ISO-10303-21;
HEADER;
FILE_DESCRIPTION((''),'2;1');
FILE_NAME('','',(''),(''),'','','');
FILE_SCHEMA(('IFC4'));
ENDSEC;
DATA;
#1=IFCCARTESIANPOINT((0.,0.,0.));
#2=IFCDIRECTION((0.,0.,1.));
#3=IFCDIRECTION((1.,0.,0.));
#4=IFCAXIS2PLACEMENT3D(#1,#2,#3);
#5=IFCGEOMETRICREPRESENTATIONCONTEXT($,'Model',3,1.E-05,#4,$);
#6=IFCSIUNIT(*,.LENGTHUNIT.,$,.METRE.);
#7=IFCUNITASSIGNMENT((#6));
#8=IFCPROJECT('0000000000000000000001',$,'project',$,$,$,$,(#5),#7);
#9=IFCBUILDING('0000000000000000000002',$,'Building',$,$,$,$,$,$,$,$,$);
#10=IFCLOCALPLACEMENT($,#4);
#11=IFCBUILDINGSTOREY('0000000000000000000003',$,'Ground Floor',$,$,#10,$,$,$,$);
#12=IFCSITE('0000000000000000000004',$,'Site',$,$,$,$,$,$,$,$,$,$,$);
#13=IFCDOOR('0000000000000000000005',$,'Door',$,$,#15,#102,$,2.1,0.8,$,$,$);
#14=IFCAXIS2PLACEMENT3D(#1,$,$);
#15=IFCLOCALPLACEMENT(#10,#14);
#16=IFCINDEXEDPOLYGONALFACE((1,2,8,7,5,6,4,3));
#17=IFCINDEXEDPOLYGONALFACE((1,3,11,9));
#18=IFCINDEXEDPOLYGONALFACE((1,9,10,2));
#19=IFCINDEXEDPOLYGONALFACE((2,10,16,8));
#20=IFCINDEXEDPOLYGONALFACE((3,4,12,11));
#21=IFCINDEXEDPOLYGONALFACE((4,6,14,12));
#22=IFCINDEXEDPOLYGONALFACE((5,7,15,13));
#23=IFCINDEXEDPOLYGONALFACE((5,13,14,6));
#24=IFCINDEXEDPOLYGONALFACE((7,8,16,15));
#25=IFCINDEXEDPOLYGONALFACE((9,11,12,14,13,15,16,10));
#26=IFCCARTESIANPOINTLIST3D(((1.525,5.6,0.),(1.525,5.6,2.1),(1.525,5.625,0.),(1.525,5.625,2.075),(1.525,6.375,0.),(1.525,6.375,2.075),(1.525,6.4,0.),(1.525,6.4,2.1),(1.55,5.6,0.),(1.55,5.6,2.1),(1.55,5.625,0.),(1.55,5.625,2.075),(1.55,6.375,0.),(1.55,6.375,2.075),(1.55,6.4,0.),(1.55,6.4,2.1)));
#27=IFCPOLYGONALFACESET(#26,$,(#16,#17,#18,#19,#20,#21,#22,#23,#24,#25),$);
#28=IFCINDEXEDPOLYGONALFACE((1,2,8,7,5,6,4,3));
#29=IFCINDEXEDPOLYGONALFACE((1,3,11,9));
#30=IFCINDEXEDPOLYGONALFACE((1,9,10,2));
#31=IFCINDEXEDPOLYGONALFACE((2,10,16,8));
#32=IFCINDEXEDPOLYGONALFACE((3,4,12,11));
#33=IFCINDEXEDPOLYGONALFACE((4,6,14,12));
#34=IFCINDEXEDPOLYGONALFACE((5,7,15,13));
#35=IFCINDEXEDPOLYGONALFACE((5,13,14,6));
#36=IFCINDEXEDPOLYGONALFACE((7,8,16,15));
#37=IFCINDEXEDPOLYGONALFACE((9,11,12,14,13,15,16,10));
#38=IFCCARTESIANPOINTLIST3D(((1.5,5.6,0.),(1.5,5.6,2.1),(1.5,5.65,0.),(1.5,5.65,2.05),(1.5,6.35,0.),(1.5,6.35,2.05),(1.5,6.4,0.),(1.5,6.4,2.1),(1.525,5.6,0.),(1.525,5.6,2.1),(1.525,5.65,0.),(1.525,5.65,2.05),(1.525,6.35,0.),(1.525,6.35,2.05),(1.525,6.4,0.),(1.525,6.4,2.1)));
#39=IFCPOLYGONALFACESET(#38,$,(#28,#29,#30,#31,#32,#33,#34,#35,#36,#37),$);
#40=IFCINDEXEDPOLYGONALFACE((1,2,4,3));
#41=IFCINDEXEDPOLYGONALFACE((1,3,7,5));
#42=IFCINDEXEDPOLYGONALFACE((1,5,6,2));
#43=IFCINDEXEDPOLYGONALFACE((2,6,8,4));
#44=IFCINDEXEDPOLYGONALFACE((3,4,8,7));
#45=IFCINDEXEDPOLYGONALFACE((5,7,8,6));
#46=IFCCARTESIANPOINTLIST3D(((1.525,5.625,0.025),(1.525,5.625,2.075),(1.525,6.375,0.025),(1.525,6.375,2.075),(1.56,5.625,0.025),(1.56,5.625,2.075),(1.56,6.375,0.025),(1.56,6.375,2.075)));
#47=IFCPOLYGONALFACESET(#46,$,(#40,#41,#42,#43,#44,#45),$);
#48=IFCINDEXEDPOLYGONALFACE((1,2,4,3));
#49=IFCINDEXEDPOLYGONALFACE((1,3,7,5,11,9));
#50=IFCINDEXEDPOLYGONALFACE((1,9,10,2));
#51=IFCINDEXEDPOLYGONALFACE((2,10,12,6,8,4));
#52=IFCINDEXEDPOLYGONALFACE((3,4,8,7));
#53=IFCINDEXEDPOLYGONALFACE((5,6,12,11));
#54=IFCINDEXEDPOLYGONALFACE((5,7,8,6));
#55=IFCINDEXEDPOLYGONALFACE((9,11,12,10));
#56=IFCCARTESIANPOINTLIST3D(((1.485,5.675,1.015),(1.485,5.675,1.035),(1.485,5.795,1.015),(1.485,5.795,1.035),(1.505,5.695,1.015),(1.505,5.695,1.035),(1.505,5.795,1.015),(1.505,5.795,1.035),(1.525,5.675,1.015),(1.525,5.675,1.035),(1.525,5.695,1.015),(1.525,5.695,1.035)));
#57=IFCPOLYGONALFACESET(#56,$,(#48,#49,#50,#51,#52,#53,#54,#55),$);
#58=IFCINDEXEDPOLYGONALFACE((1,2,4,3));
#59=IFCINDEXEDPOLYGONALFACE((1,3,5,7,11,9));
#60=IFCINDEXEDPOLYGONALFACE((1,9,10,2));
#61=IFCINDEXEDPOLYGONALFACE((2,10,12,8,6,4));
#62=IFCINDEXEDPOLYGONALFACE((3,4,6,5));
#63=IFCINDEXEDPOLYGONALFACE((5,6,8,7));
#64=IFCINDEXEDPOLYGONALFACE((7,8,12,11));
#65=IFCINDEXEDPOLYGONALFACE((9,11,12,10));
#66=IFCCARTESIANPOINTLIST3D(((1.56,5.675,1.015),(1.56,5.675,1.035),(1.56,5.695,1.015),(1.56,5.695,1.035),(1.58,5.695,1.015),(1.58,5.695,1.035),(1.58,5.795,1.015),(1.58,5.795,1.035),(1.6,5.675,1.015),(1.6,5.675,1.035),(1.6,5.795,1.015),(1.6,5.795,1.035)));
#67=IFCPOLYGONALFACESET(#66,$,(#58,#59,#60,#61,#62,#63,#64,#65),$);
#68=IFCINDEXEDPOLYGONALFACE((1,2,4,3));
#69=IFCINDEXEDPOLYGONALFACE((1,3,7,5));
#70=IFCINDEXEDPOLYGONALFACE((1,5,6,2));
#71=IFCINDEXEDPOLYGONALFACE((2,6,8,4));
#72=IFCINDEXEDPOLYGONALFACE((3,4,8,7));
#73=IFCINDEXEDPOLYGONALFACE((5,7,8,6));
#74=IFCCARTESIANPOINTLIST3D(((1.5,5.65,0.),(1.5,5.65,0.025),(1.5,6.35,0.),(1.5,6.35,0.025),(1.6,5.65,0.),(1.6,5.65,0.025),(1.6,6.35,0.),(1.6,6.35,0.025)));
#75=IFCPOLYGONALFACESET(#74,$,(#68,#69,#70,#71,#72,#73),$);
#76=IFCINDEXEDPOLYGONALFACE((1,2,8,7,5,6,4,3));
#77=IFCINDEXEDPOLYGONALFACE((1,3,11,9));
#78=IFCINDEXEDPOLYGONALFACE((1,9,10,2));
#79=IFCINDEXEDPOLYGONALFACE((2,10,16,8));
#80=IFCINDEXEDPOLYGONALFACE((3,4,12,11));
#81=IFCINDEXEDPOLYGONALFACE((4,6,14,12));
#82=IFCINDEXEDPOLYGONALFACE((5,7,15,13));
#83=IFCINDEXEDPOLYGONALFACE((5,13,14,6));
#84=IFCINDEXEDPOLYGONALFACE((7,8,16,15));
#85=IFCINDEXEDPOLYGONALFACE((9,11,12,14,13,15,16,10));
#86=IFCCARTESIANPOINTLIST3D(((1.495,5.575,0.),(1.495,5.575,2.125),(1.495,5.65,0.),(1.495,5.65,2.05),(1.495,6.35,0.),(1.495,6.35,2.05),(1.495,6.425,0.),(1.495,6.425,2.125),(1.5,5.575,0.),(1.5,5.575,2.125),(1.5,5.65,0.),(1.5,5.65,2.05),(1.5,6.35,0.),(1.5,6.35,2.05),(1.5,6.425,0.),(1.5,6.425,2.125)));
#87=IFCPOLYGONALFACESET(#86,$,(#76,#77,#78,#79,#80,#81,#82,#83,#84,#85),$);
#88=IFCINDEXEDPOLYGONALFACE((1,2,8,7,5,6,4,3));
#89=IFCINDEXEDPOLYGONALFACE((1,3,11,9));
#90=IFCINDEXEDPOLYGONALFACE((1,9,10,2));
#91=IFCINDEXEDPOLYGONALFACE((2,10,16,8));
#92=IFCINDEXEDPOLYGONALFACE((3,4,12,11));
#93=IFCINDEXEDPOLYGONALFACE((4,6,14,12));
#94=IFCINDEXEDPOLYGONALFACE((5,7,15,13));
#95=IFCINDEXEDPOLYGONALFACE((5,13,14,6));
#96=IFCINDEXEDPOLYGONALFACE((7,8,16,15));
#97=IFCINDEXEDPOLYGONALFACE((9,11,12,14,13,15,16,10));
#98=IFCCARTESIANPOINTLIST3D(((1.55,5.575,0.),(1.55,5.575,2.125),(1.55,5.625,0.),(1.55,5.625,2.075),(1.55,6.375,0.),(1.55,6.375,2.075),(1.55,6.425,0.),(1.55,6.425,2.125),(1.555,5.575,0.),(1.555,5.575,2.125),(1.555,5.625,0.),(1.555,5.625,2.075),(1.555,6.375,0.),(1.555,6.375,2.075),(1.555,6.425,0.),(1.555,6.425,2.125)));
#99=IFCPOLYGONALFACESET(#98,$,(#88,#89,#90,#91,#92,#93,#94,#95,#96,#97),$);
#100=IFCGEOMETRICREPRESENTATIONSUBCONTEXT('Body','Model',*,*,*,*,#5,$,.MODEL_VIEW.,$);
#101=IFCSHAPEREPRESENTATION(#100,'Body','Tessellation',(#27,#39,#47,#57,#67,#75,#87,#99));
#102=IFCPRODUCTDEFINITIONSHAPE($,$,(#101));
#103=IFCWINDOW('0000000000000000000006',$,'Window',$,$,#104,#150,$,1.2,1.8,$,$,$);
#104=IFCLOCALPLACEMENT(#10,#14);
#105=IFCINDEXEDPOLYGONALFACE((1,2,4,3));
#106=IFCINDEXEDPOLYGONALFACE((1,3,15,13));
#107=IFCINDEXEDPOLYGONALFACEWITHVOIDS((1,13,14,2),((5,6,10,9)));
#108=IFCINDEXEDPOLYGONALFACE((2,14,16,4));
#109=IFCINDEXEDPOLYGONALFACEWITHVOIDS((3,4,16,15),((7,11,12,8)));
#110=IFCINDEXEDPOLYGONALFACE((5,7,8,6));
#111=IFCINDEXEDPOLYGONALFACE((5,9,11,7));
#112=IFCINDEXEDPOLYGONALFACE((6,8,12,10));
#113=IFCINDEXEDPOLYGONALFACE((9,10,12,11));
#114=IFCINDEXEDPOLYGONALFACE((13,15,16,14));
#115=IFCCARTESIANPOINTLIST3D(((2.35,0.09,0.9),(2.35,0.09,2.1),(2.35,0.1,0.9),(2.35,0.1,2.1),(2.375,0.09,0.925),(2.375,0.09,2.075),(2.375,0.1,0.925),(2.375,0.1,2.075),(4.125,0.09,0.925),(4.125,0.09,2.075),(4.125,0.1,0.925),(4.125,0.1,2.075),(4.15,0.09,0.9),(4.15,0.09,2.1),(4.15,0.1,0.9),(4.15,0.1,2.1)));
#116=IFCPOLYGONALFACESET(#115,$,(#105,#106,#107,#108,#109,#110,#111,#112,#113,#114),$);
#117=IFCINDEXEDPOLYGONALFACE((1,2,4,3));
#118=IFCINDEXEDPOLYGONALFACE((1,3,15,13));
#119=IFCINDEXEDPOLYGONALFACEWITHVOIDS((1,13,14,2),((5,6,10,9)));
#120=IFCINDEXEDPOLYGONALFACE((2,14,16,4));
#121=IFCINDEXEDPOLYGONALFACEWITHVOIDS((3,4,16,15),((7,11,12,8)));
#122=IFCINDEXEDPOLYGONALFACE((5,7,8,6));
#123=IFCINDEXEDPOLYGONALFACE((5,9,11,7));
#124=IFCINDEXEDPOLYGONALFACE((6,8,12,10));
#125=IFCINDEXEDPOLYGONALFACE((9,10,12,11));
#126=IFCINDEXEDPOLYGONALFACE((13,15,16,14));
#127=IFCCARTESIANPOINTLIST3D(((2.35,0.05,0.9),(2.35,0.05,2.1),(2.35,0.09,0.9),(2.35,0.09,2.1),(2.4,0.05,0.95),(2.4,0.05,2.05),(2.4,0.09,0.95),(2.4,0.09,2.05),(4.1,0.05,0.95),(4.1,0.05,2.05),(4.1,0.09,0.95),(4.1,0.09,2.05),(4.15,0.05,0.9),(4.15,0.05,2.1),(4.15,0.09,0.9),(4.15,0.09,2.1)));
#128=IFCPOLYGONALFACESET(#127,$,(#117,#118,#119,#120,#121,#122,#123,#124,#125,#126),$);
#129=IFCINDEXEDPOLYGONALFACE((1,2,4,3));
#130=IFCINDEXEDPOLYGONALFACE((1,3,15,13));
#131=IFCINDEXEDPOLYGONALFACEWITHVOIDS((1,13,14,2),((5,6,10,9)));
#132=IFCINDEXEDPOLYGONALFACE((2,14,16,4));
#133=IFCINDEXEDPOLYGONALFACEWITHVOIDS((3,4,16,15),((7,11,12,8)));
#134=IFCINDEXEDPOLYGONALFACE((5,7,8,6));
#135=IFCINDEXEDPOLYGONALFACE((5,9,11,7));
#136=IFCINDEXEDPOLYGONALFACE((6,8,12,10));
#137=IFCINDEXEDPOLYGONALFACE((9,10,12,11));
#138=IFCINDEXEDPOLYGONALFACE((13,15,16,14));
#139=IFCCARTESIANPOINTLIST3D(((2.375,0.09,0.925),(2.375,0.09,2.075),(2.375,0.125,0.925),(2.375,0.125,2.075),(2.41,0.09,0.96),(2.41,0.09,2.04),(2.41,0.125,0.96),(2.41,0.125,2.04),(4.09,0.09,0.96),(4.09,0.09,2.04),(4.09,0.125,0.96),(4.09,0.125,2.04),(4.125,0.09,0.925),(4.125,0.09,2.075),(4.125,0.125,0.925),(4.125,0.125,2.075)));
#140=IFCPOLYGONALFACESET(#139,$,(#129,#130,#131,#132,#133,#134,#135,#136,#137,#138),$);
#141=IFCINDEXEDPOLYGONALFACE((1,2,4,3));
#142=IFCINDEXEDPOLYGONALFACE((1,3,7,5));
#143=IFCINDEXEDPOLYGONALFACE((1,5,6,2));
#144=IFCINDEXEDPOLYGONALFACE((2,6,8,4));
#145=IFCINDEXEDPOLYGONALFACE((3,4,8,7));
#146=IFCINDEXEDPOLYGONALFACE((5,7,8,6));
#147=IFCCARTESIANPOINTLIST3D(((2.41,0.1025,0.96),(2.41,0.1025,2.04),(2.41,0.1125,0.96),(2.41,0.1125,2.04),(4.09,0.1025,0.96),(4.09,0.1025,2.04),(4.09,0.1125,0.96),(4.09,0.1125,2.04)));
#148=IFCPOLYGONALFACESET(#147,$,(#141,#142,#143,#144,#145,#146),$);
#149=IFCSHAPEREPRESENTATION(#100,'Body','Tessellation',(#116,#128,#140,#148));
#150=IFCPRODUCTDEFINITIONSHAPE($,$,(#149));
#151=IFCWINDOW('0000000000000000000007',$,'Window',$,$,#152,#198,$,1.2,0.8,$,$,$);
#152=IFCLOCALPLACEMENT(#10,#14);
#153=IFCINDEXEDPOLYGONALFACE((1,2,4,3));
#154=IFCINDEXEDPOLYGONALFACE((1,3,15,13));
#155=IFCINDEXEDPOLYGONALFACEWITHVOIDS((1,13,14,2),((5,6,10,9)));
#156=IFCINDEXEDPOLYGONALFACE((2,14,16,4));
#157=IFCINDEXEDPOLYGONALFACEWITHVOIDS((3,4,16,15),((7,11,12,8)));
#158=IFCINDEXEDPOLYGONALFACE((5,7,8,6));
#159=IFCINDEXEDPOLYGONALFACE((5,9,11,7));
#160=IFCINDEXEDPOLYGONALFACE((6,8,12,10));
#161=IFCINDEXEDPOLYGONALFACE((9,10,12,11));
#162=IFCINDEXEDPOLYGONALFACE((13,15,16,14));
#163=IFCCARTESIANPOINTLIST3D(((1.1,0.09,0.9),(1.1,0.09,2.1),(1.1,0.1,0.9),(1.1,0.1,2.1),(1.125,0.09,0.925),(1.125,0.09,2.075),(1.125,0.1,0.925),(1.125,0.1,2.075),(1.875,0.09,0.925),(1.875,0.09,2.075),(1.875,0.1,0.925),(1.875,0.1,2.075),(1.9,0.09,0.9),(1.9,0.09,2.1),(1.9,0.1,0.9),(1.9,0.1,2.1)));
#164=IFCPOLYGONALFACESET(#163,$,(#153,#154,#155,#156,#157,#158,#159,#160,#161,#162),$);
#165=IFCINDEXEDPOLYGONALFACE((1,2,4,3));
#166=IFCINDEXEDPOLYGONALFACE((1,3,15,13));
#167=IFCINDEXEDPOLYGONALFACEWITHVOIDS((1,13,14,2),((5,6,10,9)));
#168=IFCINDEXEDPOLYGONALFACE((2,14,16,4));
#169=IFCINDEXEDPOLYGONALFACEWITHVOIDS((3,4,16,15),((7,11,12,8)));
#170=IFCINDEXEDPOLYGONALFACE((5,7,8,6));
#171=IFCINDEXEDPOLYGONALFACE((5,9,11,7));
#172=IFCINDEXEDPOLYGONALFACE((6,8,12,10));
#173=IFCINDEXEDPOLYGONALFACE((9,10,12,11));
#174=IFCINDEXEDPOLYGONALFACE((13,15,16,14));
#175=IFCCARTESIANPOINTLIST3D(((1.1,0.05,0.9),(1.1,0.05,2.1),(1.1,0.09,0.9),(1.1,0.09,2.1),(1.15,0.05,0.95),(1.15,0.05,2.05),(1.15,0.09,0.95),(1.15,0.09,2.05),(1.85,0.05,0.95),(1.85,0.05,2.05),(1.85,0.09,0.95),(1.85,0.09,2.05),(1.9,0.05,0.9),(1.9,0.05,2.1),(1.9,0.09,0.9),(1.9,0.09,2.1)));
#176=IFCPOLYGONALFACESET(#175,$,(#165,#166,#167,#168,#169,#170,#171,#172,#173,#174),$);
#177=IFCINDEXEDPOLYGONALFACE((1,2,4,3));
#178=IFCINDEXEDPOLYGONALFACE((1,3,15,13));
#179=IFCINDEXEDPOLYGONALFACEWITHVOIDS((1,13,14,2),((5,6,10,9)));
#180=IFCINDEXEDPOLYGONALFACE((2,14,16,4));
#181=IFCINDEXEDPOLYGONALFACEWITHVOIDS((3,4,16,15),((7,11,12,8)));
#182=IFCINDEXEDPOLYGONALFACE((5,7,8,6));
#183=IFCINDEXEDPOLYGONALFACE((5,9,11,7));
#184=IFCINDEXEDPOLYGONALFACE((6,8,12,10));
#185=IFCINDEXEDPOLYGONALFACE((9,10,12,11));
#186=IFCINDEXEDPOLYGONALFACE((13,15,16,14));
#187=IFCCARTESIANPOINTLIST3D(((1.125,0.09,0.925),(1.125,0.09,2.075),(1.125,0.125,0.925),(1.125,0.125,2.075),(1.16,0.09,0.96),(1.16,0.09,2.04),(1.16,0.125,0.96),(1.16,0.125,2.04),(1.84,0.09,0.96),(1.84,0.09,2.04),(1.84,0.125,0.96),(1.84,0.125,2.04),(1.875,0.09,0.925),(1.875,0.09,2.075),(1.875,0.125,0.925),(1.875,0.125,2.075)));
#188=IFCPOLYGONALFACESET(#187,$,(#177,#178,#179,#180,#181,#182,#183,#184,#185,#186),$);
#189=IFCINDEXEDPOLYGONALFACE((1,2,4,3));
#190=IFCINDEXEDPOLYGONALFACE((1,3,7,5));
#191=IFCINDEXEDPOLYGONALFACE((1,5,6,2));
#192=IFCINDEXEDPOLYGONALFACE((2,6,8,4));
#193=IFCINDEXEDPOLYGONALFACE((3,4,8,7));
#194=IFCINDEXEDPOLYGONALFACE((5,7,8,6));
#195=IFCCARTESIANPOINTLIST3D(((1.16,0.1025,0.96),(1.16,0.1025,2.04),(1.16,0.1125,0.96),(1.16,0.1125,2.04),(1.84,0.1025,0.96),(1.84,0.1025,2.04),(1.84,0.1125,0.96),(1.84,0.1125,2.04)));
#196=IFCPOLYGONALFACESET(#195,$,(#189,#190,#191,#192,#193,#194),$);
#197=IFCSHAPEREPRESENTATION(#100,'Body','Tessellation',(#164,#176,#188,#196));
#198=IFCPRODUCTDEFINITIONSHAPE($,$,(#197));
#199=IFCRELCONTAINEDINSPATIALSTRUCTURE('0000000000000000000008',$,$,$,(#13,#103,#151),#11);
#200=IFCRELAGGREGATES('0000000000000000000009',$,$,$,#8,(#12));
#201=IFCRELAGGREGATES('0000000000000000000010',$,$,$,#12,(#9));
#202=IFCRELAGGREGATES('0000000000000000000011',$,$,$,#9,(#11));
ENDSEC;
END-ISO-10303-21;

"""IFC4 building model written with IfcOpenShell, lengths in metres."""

from ifc_helpers import new_model, si_unit, frame, origin_with_axes, place, context, subcontext, project, spatial, line, indexed_curve, outline, extrude, element, save


model = new_model("IFC4")

# Units and contexts
model_context = context("Model", 3, precision=1e-05, world=origin_with_axes())
body_context = subcontext(model_context, "Body", "Model", "MODEL_VIEW")
ifc_project = project(units=[si_unit("LENGTHUNIT", "METRE")], contexts=[model_context])

# Site, building, storey
site = spatial("IfcSite", under=ifc_project, Name="Site")
building = spatial("IfcBuilding", under=site, Name="Building")
storey_placement = place(None, origin_with_axes())
storey = spatial("IfcBuildingStorey", under=building, at=storey_placement, Name="Ground Floor")

# Door
door_1_placement = place(storey_placement, frame((1.5, 6.4, 0.0), z_axis=(0.0, 0.0, 1.0), x_axis=(0.0, -1.0, 0.0)))
element("IfcDoor", 1, at=door_1_placement, inside=storey, Name="Door", OverallHeight=2.1, OverallWidth=0.8, context=body_context, shape_type="SweptSolid", body=[
    extrude(outline(indexed_curve([(0.0, 0.0), (0.0, 2.1), (0.8, 2.1), (0.8, 0.0), (0.775, 0.0), (0.775, 2.075), (0.025, 2.075), (0.025, 0.0)], segments=[line(1, 2, 3, 4, 5, 6, 7, 8, 1)])), frame((0.0, 0.025, 0.0), z_axis=(0.0, -1.0, 0.0), x_axis=(1.0, 0.0, 0.0)), (0.0, 0.0, -1.0), 0.025),
    extrude(outline(indexed_curve([(0.0, 0.0), (0.0, 2.1), (0.8, 2.1), (0.8, 0.0), (0.75, 0.0), (0.75, 2.05), (0.05, 2.05), (0.05, 0.0)], segments=[line(1, 2, 3, 4, 5, 6, 7, 8, 1)])), frame((0.0, 0.0, 0.0), z_axis=(0.0, -1.0, 0.0), x_axis=(1.0, 0.0, 0.0)), (0.0, 0.0, -1.0), 0.025),
    extrude(outline(indexed_curve([(0.0, 0.0), (0.75, 0.0), (0.75, 0.035), (0.0, 0.035)], segments=[line(1, 2, 3, 4, 1)])), frame((0.025, 0.025, 0.025), z_axis=(0.0, 0.0, 1.0), x_axis=(1.0, 0.0, 0.0)), (0.0, 0.0, 1.0), 2.05),
    extrude(outline(indexed_curve([(0.0, 0.0), (0.0, -0.04), (-0.12, -0.04), (-0.12, -0.02), (-0.02, -0.02), (-0.02, 0.0)], segments=[line(1, 2, 3, 4, 5, 6, 1)])), frame((0.725, 0.025, 1.015), z_axis=(0.0, 0.0, 1.0), x_axis=(1.0, 0.0, 0.0)), (0.0, 0.0, 1.0), 0.02),
    extrude(outline(indexed_curve([(0.0, 0.0), (0.0, 0.04), (-0.12, 0.04), (-0.12, 0.02), (-0.02, 0.02), (-0.02, 0.0)], segments=[line(1, 2, 3, 4, 5, 6, 1)])), frame((0.725, 0.06, 1.015), z_axis=(0.0, 0.0, 1.0), x_axis=(1.0, 0.0, 0.0)), (0.0, 0.0, 1.0), 0.02),
    extrude(outline(indexed_curve([(0.0, 0.0), (0.7, 0.0), (0.7, 0.1), (0.0, 0.1)], segments=[line(1, 2, 3, 4, 1)])), frame((0.05, 0.0, 0.0), z_axis=(0.0, 0.0, 1.0), x_axis=(1.0, 0.0, 0.0)), (0.0, 0.0, 1.0), 0.025),
    extrude(outline(indexed_curve([(0.0, 0.0), (0.0, 2.125), (0.85, 2.125), (0.85, 0.0), (0.775, 0.0), (0.775, 2.05), (0.075, 2.05), (0.075, 0.0)], segments=[line(1, 2, 3, 4, 5, 6, 7, 8, 1)])), frame((-0.025, -0.005, 0.0), z_axis=(0.0, -1.0, 0.0), x_axis=(1.0, 0.0, 0.0)), (0.0, 0.0, -1.0), 0.005),
    extrude(outline(indexed_curve([(0.0, 0.0), (0.0, 2.125), (0.85, 2.125), (0.85, 0.0), (0.8, 0.0), (0.8, 2.075), (0.05, 2.075), (0.05, 0.0)], segments=[line(1, 2, 3, 4, 5, 6, 7, 8, 1)])), frame((-0.025, 0.05, 0.0), z_axis=(0.0, -1.0, 0.0), x_axis=(1.0, 0.0, 0.0)), (0.0, 0.0, -1.0), 0.005),
])

# Windows
window_1_placement = place(storey_placement, frame((2.35, 0.0, 0.9), z_axis=(0.0, 0.0, 1.0), x_axis=(1.0, 0.0, 0.0)))
element("IfcWindow", 2, at=window_1_placement, inside=storey, Name="Window", OverallHeight=1.2, OverallWidth=1.8, context=body_context, shape_type="SweptSolid", body=[
    extrude(outline(indexed_curve([(0.0, 0.0), (1.8, 0.0), (1.8, 1.2), (0.0, 1.2)], segments=[line(1, 2, 3, 4, 1)]), holes=[indexed_curve([(0.025, 0.025), (1.775, 0.025), (1.775, 1.175), (0.025, 1.175)], segments=[line(1, 2, 3, 4, 1)])]), frame((0.0, 0.09, 0.0), z_axis=(0.0, -1.0, 0.0), x_axis=(1.0, 0.0, 0.0)), (0.0, 0.0, -1.0), 0.01),
    extrude(outline(indexed_curve([(0.0, 0.0), (1.8, 0.0), (1.8, 1.2), (0.0, 1.2)], segments=[line(1, 2, 3, 4, 1)]), holes=[indexed_curve([(0.05, 0.05), (1.75, 0.05), (1.75, 1.15), (0.05, 1.15)], segments=[line(1, 2, 3, 4, 1)])]), frame((0.0, 0.05, 0.0), z_axis=(0.0, -1.0, 0.0), x_axis=(1.0, 0.0, 0.0)), (0.0, 0.0, -1.0), 0.04),
    extrude(outline(indexed_curve([(0.0, 0.0), (1.75, 0.0), (1.75, 1.15), (0.0, 1.15)], segments=[line(1, 2, 3, 4, 1)]), holes=[indexed_curve([(0.035, 0.035), (1.715, 0.035), (1.715, 1.115), (0.035, 1.115)], segments=[line(1, 2, 3, 4, 1)])]), frame((0.025, 0.09, 0.025), z_axis=(0.0, -1.0, 0.0), x_axis=(1.0, 0.0, 0.0)), (0.0, 0.0, -1.0), 0.035),
    extrude(outline(indexed_curve([(0.035, 0.035), (1.715, 0.035), (1.715, 1.115), (0.035, 1.115)], segments=[line(1, 2, 3, 4, 1)])), frame((0.025, 0.1025, 0.025), z_axis=(0.0, -1.0, 0.0), x_axis=(1.0, 0.0, 0.0)), (0.0, 0.0, -1.0), 0.01),
])
window_2_placement = place(storey_placement, frame((1.1, 0.0, 0.9), z_axis=(0.0, 0.0, 1.0), x_axis=(1.0, 0.0, 0.0)))
element("IfcWindow", 3, at=window_2_placement, inside=storey, Name="Window", OverallHeight=1.2, OverallWidth=0.8, context=body_context, shape_type="SweptSolid", body=[
    extrude(outline(indexed_curve([(0.0, 0.0), (0.8, 0.0), (0.8, 1.2), (0.0, 1.2)], segments=[line(1, 2, 3, 4, 1)]), holes=[indexed_curve([(0.025, 0.025), (0.775, 0.025), (0.775, 1.175), (0.025, 1.175)], segments=[line(1, 2, 3, 4, 1)])]), frame((0.0, 0.09, 0.0), z_axis=(0.0, -1.0, 0.0), x_axis=(1.0, 0.0, 0.0)), (0.0, 0.0, -1.0), 0.01),
    extrude(outline(indexed_curve([(0.0, 0.0), (0.8, 0.0), (0.8, 1.2), (0.0, 1.2)], segments=[line(1, 2, 3, 4, 1)]), holes=[indexed_curve([(0.05, 0.05), (0.75, 0.05), (0.75, 1.15), (0.05, 1.15)], segments=[line(1, 2, 3, 4, 1)])]), frame((0.0, 0.05, 0.0), z_axis=(0.0, -1.0, 0.0), x_axis=(1.0, 0.0, 0.0)), (0.0, 0.0, -1.0), 0.04),
    extrude(outline(indexed_curve([(0.0, 0.0), (0.75, 0.0), (0.75, 1.15), (0.0, 1.15)], segments=[line(1, 2, 3, 4, 1)]), holes=[indexed_curve([(0.035, 0.035), (0.715, 0.035), (0.715, 1.115), (0.035, 1.115)], segments=[line(1, 2, 3, 4, 1)])]), frame((0.025, 0.09, 0.025), z_axis=(0.0, -1.0, 0.0), x_axis=(1.0, 0.0, 0.0)), (0.0, 0.0, -1.0), 0.035),
    extrude(outline(indexed_curve([(0.035, 0.035), (0.715, 0.035), (0.715, 1.115), (0.035, 1.115)], segments=[line(1, 2, 3, 4, 1)])), frame((0.025, 0.1025, 0.025), z_axis=(0.0, -1.0, 0.0), x_axis=(1.0, 0.0, 0.0)), (0.0, 0.0, -1.0), 0.01),
])

save(model, "model.ifc")
